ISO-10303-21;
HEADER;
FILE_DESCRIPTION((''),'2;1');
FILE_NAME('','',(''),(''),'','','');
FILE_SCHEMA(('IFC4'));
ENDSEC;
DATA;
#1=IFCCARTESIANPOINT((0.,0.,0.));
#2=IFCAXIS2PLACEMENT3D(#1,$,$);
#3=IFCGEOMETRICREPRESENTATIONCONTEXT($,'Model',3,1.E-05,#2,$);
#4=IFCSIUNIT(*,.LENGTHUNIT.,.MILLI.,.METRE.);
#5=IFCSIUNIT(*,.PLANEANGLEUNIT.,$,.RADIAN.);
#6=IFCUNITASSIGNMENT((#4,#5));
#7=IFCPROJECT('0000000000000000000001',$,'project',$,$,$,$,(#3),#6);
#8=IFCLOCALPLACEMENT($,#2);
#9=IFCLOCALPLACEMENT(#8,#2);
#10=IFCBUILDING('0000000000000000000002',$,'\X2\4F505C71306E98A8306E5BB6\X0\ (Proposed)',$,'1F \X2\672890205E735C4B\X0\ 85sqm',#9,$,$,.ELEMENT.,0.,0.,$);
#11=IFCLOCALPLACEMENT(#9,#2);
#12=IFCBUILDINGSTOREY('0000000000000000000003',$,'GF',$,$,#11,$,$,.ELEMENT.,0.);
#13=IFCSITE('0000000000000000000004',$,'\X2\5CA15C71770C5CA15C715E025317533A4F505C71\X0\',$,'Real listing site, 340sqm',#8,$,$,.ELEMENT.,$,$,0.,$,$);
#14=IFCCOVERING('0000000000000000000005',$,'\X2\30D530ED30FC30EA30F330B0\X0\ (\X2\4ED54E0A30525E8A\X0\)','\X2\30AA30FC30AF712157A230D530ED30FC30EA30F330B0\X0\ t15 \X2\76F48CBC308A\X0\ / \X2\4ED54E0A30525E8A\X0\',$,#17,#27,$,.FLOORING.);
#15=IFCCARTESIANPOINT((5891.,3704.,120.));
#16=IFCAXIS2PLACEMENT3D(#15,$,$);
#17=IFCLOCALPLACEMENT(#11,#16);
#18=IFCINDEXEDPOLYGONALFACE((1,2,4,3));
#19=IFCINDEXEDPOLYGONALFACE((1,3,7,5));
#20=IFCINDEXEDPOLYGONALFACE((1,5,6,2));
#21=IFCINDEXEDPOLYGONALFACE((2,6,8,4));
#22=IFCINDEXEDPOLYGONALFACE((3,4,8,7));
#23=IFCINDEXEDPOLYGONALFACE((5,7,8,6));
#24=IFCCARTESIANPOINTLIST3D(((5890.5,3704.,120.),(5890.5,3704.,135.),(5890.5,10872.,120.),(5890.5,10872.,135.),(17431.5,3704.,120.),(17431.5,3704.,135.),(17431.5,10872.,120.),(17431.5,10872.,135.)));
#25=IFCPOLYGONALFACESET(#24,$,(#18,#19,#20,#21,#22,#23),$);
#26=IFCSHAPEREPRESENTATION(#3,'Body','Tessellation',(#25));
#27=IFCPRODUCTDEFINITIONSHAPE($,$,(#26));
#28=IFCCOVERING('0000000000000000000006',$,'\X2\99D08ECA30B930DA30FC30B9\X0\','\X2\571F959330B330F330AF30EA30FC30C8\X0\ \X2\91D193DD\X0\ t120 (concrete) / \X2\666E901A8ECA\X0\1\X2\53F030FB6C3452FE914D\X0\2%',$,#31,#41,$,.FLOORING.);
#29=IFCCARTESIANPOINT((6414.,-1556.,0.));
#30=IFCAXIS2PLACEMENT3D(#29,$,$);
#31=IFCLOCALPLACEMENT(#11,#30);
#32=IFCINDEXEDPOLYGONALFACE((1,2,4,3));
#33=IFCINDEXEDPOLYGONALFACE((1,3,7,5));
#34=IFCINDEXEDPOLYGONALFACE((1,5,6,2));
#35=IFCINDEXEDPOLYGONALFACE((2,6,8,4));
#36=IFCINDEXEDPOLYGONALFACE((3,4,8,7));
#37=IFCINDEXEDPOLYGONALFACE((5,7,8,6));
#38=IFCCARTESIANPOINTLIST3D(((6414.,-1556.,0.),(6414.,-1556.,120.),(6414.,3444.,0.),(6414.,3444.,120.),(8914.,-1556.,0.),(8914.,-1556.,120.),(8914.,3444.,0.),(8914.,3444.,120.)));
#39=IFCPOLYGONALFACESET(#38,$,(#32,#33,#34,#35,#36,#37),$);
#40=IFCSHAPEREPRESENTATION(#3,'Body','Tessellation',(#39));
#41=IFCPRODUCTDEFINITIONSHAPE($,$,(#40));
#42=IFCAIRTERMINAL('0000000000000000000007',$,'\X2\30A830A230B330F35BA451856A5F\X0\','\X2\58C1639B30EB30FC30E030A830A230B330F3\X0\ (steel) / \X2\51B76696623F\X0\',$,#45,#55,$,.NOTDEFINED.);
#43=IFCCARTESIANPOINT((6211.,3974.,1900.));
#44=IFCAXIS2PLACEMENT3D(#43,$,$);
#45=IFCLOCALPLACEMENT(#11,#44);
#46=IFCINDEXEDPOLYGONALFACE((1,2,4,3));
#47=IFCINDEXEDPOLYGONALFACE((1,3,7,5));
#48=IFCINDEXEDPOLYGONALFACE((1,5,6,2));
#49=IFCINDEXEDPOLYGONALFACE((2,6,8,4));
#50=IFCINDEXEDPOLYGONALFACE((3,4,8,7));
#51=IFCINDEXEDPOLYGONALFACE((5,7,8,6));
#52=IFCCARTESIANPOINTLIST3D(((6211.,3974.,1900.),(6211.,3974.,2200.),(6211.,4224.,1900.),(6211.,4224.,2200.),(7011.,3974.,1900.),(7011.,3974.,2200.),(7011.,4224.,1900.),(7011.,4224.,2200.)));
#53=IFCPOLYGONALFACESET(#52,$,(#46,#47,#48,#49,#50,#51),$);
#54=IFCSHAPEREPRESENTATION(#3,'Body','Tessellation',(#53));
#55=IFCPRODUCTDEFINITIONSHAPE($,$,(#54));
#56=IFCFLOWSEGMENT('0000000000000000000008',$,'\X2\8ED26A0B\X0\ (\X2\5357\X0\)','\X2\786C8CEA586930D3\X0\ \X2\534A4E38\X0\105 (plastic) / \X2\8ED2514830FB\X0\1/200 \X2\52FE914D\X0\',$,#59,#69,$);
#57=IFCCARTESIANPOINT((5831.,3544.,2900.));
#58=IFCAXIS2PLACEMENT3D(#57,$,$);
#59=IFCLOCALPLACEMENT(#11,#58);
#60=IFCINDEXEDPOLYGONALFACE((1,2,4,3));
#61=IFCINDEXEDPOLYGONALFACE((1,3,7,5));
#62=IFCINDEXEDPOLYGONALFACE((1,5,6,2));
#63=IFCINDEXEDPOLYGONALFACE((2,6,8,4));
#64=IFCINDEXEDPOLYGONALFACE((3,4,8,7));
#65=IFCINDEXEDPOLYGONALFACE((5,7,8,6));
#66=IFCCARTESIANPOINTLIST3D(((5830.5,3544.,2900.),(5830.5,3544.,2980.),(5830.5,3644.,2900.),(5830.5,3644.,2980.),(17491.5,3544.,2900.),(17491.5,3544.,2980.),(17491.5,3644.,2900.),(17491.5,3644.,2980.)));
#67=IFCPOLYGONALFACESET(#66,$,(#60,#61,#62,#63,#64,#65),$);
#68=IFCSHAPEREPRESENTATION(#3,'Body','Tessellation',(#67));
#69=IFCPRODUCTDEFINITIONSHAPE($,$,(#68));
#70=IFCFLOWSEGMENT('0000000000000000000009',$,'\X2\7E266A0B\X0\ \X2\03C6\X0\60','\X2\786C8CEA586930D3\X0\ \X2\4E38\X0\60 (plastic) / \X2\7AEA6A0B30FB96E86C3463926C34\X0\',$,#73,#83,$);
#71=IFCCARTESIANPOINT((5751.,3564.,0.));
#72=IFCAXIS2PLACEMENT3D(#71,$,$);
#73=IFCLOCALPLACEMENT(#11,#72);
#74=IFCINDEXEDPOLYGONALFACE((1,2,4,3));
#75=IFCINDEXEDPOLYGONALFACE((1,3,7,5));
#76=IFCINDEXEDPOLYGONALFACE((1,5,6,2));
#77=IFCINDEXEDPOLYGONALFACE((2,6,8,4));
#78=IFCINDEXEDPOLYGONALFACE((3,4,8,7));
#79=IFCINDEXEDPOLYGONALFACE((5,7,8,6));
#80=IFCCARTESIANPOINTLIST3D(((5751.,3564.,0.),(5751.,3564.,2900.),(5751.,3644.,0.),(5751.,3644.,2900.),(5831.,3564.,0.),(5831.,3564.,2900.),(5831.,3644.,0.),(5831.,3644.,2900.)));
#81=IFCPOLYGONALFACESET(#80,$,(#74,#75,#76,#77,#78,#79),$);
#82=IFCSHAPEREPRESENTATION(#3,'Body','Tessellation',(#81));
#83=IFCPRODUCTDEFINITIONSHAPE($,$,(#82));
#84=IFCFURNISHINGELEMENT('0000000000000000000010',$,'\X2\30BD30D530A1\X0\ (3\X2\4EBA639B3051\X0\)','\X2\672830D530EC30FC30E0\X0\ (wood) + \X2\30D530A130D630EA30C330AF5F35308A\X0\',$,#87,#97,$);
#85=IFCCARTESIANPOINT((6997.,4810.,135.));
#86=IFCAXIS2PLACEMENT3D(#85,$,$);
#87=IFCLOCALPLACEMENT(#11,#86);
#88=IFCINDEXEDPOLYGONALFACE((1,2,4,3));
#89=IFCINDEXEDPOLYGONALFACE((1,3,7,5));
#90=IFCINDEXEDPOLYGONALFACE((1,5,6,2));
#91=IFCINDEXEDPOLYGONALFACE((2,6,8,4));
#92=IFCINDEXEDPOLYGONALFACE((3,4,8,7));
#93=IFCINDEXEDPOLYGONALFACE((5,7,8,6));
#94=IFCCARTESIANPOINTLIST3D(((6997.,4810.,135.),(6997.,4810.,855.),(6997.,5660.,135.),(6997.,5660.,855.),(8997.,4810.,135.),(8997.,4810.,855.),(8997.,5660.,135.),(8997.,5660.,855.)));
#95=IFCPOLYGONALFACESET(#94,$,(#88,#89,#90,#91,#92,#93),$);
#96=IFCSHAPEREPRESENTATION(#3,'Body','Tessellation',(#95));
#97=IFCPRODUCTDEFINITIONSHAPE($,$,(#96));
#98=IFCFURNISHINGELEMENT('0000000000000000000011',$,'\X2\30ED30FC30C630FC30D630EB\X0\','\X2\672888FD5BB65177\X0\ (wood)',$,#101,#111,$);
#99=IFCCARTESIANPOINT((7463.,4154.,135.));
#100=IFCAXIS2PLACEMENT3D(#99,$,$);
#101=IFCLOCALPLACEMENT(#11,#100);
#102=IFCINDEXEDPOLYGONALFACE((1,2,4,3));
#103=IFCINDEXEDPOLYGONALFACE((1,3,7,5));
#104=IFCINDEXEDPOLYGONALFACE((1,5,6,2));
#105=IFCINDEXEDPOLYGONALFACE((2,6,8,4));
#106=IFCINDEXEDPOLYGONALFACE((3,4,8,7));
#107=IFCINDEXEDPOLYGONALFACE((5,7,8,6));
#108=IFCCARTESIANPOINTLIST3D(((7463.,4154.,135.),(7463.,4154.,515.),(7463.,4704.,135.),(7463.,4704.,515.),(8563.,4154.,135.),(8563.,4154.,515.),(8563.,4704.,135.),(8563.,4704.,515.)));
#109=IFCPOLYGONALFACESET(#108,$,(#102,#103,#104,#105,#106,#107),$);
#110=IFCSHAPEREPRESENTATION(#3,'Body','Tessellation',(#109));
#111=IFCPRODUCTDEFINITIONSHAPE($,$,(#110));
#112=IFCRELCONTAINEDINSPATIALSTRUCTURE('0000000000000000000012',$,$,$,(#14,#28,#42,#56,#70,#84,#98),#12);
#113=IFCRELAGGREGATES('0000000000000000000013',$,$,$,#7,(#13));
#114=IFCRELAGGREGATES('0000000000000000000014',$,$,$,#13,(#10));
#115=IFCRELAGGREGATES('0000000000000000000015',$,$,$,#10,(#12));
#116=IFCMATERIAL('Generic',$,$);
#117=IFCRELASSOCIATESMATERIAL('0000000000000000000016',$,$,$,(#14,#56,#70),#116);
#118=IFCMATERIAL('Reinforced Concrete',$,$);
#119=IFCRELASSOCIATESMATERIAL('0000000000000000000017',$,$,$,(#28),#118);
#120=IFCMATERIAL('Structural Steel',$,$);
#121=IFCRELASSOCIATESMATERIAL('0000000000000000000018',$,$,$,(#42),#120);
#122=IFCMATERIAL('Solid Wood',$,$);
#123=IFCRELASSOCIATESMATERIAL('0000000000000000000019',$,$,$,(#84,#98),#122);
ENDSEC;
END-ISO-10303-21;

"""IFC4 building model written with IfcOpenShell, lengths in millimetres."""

from ifc_helpers import new_model, si_unit, frame, frame_2d, origin, place, context, project, spatial, rectangle, extrude, material, element, save


model = new_model("IFC4")

# Units and contexts
model_context = context("Model", 3, precision=1e-05, world=origin())
ifc_project = project(units=[si_unit("LENGTHUNIT", "METRE", prefix="MILLI"), si_unit("PLANEANGLEUNIT", "RADIAN")], contexts=[model_context])

# Site, building, storey
site_placement = place(None, origin())
site = spatial("IfcSite", under=ifc_project, at=site_placement, Name="岡山県岡山市北区佐山", ObjectType="Real listing site, 340sqm", CompositionType="ELEMENT", RefElevation=0.0)
building_placement = place(site_placement, origin())
building = spatial("IfcBuilding", under=site, at=building_placement, Name="佐山の風の家 (Proposed)", ObjectType="1F 木造平屋 85sqm", CompositionType="ELEMENT", ElevationOfRefHeight=0.0, ElevationOfTerrain=0.0)
storey_placement = place(building_placement, origin())
storey = spatial("IfcBuildingStorey", under=building, at=storey_placement, Name="GF", CompositionType="ELEMENT", Elevation=0.0)

# Shared definitions
ifc_material_1 = material(Name="Solid Wood")

# Shared definitions
ifc_material_2 = material(Name="Reinforced Concrete")

# Shared definitions
ifc_material_3 = material(Name="Structural Steel")

# Coverings
ifc_material_4 = material(Name="Generic")
covering_1_placement = place(storey_placement, frame((5891.0, 3704.0, 120.0)))
element("IfcCovering", 1, at=covering_1_placement, inside=storey, material=ifc_material_4, Name="フローリング (仕上げ床)", Description="オーク無垢フローリング t15 直貼り / 仕上げ床", PredefinedType="FLOORING", context=model_context, shape_type="SweptSolid", body=[
    extrude(rectangle(XDim=11541.0, YDim=7168.0, at=frame_2d((5770.0, 3584.0))), frame((5891.0, 3704.0, 120.0)), (0.0, 0.0, 1.0), 15.0),
])
covering_2_placement = place(storey_placement, frame((6414.0, -1556.0, 0.0)))
element("IfcCovering", 2, at=covering_2_placement, inside=storey, material=ifc_material_2, Name="駐車スペース", Description="土間コンクリート 金鏝 t120 (concrete) / 普通車1台・水勾配2%", PredefinedType="FLOORING", context=model_context, shape_type="SweptSolid", body=[
    extrude(rectangle(XDim=2500.0, YDim=5000.0, at=frame_2d((1250.0, 2500.0))), frame((6414.0, -1556.0, 0.0)), (0.0, 0.0, 1.0), 120.0),
])

# Air terminal
air_terminal_placement = place(storey_placement, frame((6211.0, 3974.0, 1900.0)))
element("IfcAirTerminal", 3, at=air_terminal_placement, inside=storey, material=ifc_material_3, Name="エアコン室内機", Description="壁掛ルームエアコン (steel) / 冷暖房", PredefinedType="NOTDEFINED", context=model_context, shape_type="SweptSolid", body=[
    extrude(rectangle(XDim=800.0, YDim=250.0, at=frame_2d((400.0, 125.0))), frame((6211.0, 3974.0, 1900.0)), (0.0, 0.0, 1.0), 300.0),
])

# Flow segments
flow_segment_1_placement = place(storey_placement, frame((5831.0, 3544.0, 2900.0)))
element("IfcFlowSegment", 4, at=flow_segment_1_placement, inside=storey, material=ifc_material_4, Name="軒樋 (南)", Description="硬質塩ビ 半丸105 (plastic) / 軒先・1/200 勾配", context=model_context, shape_type="SweptSolid", body=[
    extrude(rectangle(XDim=11661.0, YDim=100.0, at=frame_2d((5830.0, 50.0))), frame((5831.0, 3544.0, 2900.0)), (0.0, 0.0, 1.0), 80.0),
])
flow_segment_2_placement = place(storey_placement, frame((5751.0, 3564.0, 0.0)))
element("IfcFlowSegment", 5, at=flow_segment_2_placement, inside=storey, material=ifc_material_4, Name="縦樋 φ60", Description="硬質塩ビ 丸60 (plastic) / 竪樋・雨水排水", context=model_context, shape_type="SweptSolid", body=[
    extrude(rectangle(XDim=80.0, YDim=80.0, at=frame_2d((40.0, 40.0))), frame((5751.0, 3564.0, 0.0)), (0.0, 0.0, 1.0), 2900.0),
])

# Furnishing elements
furnishing_1_placement = place(storey_placement, frame((6997.0, 4810.0, 135.0)))
element("IfcFurnishingElement", 6, at=furnishing_1_placement, inside=storey, material=ifc_material_1, Name="ソファ (3人掛け)", Description="木フレーム (wood) + ファブリック張り", context=model_context, shape_type="SweptSolid", body=[
    extrude(rectangle(XDim=2000.0, YDim=850.0, at=frame_2d((1000.0, 425.0))), frame((6997.0, 4810.0, 135.0)), (0.0, 0.0, 1.0), 720.0),
])
furnishing_2_placement = place(storey_placement, frame((7463.0, 4154.0, 135.0)))
element("IfcFurnishingElement", 7, at=furnishing_2_placement, inside=storey, material=ifc_material_1, Name="ローテーブル", Description="木製家具 (wood)", context=model_context, shape_type="SweptSolid", body=[
    extrude(rectangle(XDim=1100.0, YDim=550.0, at=frame_2d((550.0, 275.0))), frame((7463.0, 4154.0, 135.0)), (0.0, 0.0, 1.0), 380.0),
])

save(model, "model.ifc")
